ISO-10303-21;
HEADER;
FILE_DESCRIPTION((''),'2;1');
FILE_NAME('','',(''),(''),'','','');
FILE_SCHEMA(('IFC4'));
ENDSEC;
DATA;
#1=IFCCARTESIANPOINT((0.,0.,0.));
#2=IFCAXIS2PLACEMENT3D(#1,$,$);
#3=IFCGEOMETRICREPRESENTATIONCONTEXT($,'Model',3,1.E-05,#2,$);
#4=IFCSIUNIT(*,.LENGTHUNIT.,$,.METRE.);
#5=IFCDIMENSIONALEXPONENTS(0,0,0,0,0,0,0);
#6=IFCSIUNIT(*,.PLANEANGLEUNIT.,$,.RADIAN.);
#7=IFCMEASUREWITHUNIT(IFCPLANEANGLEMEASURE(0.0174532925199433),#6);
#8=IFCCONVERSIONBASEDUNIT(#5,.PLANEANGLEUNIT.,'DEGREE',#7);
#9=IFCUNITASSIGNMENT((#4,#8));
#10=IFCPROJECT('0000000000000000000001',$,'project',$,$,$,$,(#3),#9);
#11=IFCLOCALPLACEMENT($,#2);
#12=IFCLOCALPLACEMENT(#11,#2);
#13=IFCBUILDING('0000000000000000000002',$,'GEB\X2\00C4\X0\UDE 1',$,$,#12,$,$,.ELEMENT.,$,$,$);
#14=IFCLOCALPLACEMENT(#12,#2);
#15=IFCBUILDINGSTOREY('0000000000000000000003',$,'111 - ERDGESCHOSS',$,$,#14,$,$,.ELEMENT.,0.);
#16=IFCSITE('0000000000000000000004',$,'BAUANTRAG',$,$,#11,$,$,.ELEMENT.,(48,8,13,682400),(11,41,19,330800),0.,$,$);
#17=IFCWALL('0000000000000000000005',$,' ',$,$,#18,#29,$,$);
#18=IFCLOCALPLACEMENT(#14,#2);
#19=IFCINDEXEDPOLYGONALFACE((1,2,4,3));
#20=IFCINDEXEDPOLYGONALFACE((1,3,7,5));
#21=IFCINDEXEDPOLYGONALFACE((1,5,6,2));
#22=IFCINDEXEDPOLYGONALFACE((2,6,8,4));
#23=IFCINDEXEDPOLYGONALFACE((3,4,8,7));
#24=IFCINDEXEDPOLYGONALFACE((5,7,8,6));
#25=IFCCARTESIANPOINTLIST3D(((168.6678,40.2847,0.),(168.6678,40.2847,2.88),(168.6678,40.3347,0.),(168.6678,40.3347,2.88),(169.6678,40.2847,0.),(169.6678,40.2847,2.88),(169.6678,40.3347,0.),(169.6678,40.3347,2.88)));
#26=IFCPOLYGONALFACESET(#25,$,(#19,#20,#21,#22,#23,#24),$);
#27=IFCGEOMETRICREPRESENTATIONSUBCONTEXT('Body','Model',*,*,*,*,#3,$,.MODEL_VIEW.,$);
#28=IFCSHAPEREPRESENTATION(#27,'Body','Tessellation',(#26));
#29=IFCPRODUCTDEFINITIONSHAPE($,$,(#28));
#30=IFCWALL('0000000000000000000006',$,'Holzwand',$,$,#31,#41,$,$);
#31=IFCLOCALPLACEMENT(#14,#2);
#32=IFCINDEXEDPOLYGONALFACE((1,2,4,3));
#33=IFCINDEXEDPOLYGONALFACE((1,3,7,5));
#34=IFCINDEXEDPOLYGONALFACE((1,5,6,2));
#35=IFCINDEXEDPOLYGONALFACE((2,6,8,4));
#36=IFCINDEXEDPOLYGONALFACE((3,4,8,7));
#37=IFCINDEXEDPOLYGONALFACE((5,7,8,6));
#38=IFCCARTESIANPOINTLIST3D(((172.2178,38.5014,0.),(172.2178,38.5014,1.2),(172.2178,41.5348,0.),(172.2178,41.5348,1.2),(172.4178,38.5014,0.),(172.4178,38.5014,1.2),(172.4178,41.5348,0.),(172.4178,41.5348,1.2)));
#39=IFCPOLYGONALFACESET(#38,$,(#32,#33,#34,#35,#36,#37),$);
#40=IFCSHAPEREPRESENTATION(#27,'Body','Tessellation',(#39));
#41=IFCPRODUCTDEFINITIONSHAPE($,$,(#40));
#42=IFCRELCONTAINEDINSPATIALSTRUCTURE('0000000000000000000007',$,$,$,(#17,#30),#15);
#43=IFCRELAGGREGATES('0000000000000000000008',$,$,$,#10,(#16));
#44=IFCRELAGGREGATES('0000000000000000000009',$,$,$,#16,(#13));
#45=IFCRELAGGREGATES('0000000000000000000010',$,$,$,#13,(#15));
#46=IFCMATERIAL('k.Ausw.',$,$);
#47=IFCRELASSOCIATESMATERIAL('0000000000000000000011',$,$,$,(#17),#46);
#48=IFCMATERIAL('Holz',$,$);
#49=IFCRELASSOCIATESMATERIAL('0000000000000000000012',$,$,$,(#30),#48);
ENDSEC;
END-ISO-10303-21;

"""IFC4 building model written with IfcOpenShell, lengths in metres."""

from ifc_helpers import new_model, entity, si_unit, converted_unit, frame, origin, origin_with_axes, place, context, subcontext, project, spatial, indexed_curve, outline, extrude, material, element, save


model = new_model("IFC4")

# Units and contexts
model_context = context("Model", 3, precision=1e-05, world=origin())
body_context = subcontext(model_context, "Body", "Model", "MODEL_VIEW")
ifc_project = project(units=[si_unit("LENGTHUNIT", "METRE"), converted_unit("PLANEANGLEUNIT", "DEGREE", entity("IfcPlaneAngleMeasure", 0.0174532925199433), si_unit("PLANEANGLEUNIT", "RADIAN"), dimensions=[0, 0, 0, 0, 0, 0, 0])], contexts=[model_context])

# Site, building, storey
site_placement = place(None, origin())
site = spatial("IfcSite", under=ifc_project, at=site_placement, Name="BAUANTRAG", CompositionType="ELEMENT", RefLatitude=(48, 8, 13, 682400), RefLongitude=(11, 41, 19, 330800), RefElevation=0.0)
building_placement = place(site_placement, origin())
building = spatial("IfcBuilding", under=site, at=building_placement, Name="GEBÄUDE 1", CompositionType="ELEMENT")
storey_placement = place(building_placement, origin())
storey = spatial("IfcBuildingStorey", under=building, at=storey_placement, Name="111 - ERDGESCHOSS", CompositionType="ELEMENT", Elevation=0.0)

# Walls
ifc_material_1 = material(Name="k.Ausw.")
wall_1_placement = place(storey_placement, frame((168.6678, 40.2847, 0.0)))
element("IfcWall", 1, at=wall_1_placement, inside=storey, material=ifc_material_1, Name=" ", context=body_context, shape_type="SweptSolid", body=[
    extrude(outline(indexed_curve([(0.0, 0.0), (1.0, 0.0), (1.0, 0.05), (0.0, 0.05), (0.0, 0.0)], self_intersect=False)), origin_with_axes(), (0.0, 0.0, 1.0), 2.88),
])
ifc_material_2 = material(Name="Holz")
wall_2_placement = place(storey_placement, frame((172.4178, 38.5014, 0.0), z_axis=(0.0, 0.0, 1.0), x_axis=(0.0, 1.0, 0.0)))
element("IfcWall", 2, at=wall_2_placement, inside=storey, material=ifc_material_2, Name="Holzwand", context=body_context, shape_type="SweptSolid", body=[
    extrude(outline(indexed_curve([(0.0, -0.2), (3.0334, -0.2), (3.0334, 0.0), (0.0, 0.0), (0.0, -0.2)], self_intersect=False)), frame((0.0, 0.2, 0.0), z_axis=(0.0, 0.0, 1.0), x_axis=(1.0, 0.0, 0.0)), (0.0, 0.0, 1.0), 1.2),
])

save(model, "model.ifc")
